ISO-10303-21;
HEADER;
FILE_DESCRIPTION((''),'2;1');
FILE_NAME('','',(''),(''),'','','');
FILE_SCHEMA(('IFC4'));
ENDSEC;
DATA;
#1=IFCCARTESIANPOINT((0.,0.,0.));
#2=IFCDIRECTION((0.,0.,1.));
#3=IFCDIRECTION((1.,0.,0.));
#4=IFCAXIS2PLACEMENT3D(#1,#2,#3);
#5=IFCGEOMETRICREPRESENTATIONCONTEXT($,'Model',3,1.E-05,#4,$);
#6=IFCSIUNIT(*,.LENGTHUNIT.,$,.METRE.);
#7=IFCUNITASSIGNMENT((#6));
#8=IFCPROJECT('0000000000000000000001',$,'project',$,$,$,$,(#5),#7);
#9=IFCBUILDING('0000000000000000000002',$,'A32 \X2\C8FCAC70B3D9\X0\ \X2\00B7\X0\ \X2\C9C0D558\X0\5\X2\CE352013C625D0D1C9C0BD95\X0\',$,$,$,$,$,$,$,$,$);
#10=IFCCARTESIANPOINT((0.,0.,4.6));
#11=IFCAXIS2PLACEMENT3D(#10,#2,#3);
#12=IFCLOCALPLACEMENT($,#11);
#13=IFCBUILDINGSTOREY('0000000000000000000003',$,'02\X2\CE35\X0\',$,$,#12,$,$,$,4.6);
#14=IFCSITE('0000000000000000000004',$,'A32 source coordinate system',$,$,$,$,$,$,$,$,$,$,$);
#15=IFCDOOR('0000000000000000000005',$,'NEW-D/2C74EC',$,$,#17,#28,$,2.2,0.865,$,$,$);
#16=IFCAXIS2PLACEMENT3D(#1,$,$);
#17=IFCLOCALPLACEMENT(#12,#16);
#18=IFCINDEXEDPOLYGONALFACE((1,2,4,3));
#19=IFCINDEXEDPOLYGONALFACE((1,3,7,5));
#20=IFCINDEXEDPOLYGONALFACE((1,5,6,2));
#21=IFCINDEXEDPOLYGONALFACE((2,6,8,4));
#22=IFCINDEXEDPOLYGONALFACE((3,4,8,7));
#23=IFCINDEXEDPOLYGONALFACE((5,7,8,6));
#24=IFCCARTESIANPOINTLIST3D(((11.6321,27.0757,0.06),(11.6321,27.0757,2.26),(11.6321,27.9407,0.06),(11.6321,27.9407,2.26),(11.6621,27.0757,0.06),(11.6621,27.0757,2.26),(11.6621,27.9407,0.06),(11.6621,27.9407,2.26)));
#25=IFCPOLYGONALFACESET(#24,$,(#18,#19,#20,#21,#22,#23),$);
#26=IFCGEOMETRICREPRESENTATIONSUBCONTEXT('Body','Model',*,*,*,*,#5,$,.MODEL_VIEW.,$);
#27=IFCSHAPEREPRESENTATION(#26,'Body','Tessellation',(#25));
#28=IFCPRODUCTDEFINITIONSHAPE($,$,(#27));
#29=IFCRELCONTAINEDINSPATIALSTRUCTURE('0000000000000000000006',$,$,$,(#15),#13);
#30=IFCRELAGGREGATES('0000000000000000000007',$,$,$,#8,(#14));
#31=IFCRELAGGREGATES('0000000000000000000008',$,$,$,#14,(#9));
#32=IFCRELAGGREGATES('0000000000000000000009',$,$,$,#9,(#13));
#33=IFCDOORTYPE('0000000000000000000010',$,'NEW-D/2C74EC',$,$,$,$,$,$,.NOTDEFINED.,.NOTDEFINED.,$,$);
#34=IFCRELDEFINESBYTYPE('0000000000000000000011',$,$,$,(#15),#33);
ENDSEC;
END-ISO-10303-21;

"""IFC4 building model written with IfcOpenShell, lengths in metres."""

from ifc_helpers import new_model, si_unit, frame, origin, origin_with_axes, place, context, subcontext, project, spatial, polyline, outline, extrude, source, transform, mapped, type_object, type_shapes, element, save


model = new_model("IFC4")

# Units and contexts
model_context = context("Model", 3, precision=1e-05, world=origin_with_axes())
body_context = subcontext(model_context, "Body", "Model", "MODEL_VIEW")
ifc_project = project(units=[si_unit("LENGTHUNIT", "METRE")], contexts=[model_context])

# Site, building, storey
site = spatial("IfcSite", under=ifc_project, Name="A32 source coordinate system")
building = spatial("IfcBuilding", under=site, Name="A32 주거동 · 지하5층–옥탑지붕")
storey_placement = place(None, frame((0.0, 0.0, 4.6), z_axis=(0.0, 0.0, 1.0), x_axis=(1.0, 0.0, 0.0)))
storey = spatial("IfcBuildingStorey", under=building, at=storey_placement, Name="02층", Elevation=4.6)

# Door
door_type_1 = type_object("IfcDoorType", Name="NEW-D/2C74EC", OperationType="NOTDEFINED", PredefinedType="NOTDEFINED")
shared_shape_1 = source(origin(), body_context, "Body", "SweptSolid", [
    extrude(outline(polyline([(11.6321, 27.9407), (11.6621, 27.9407), (11.6621, 27.0757), (11.6321, 27.0757), (11.6321, 27.9407)])), frame((0.0, 0.0, 0.06)), (0.0, 0.0, 1.0), 2.2),
])
type_shapes(door_type_1, [shared_shape_1])
door_1_placement = place(storey_placement, origin_with_axes())
element("IfcDoor", 1, at=door_1_placement, inside=storey, type_object=door_type_1, Name="NEW-D/2C74EC", OverallHeight=2.2, OverallWidth=0.865, context=body_context, shape_type="MappedRepresentation", body=[
    mapped(shared_shape_1, transform((0.0, 0.0, 0.0), scale=1.0)),
])

save(model, "model.ifc")
